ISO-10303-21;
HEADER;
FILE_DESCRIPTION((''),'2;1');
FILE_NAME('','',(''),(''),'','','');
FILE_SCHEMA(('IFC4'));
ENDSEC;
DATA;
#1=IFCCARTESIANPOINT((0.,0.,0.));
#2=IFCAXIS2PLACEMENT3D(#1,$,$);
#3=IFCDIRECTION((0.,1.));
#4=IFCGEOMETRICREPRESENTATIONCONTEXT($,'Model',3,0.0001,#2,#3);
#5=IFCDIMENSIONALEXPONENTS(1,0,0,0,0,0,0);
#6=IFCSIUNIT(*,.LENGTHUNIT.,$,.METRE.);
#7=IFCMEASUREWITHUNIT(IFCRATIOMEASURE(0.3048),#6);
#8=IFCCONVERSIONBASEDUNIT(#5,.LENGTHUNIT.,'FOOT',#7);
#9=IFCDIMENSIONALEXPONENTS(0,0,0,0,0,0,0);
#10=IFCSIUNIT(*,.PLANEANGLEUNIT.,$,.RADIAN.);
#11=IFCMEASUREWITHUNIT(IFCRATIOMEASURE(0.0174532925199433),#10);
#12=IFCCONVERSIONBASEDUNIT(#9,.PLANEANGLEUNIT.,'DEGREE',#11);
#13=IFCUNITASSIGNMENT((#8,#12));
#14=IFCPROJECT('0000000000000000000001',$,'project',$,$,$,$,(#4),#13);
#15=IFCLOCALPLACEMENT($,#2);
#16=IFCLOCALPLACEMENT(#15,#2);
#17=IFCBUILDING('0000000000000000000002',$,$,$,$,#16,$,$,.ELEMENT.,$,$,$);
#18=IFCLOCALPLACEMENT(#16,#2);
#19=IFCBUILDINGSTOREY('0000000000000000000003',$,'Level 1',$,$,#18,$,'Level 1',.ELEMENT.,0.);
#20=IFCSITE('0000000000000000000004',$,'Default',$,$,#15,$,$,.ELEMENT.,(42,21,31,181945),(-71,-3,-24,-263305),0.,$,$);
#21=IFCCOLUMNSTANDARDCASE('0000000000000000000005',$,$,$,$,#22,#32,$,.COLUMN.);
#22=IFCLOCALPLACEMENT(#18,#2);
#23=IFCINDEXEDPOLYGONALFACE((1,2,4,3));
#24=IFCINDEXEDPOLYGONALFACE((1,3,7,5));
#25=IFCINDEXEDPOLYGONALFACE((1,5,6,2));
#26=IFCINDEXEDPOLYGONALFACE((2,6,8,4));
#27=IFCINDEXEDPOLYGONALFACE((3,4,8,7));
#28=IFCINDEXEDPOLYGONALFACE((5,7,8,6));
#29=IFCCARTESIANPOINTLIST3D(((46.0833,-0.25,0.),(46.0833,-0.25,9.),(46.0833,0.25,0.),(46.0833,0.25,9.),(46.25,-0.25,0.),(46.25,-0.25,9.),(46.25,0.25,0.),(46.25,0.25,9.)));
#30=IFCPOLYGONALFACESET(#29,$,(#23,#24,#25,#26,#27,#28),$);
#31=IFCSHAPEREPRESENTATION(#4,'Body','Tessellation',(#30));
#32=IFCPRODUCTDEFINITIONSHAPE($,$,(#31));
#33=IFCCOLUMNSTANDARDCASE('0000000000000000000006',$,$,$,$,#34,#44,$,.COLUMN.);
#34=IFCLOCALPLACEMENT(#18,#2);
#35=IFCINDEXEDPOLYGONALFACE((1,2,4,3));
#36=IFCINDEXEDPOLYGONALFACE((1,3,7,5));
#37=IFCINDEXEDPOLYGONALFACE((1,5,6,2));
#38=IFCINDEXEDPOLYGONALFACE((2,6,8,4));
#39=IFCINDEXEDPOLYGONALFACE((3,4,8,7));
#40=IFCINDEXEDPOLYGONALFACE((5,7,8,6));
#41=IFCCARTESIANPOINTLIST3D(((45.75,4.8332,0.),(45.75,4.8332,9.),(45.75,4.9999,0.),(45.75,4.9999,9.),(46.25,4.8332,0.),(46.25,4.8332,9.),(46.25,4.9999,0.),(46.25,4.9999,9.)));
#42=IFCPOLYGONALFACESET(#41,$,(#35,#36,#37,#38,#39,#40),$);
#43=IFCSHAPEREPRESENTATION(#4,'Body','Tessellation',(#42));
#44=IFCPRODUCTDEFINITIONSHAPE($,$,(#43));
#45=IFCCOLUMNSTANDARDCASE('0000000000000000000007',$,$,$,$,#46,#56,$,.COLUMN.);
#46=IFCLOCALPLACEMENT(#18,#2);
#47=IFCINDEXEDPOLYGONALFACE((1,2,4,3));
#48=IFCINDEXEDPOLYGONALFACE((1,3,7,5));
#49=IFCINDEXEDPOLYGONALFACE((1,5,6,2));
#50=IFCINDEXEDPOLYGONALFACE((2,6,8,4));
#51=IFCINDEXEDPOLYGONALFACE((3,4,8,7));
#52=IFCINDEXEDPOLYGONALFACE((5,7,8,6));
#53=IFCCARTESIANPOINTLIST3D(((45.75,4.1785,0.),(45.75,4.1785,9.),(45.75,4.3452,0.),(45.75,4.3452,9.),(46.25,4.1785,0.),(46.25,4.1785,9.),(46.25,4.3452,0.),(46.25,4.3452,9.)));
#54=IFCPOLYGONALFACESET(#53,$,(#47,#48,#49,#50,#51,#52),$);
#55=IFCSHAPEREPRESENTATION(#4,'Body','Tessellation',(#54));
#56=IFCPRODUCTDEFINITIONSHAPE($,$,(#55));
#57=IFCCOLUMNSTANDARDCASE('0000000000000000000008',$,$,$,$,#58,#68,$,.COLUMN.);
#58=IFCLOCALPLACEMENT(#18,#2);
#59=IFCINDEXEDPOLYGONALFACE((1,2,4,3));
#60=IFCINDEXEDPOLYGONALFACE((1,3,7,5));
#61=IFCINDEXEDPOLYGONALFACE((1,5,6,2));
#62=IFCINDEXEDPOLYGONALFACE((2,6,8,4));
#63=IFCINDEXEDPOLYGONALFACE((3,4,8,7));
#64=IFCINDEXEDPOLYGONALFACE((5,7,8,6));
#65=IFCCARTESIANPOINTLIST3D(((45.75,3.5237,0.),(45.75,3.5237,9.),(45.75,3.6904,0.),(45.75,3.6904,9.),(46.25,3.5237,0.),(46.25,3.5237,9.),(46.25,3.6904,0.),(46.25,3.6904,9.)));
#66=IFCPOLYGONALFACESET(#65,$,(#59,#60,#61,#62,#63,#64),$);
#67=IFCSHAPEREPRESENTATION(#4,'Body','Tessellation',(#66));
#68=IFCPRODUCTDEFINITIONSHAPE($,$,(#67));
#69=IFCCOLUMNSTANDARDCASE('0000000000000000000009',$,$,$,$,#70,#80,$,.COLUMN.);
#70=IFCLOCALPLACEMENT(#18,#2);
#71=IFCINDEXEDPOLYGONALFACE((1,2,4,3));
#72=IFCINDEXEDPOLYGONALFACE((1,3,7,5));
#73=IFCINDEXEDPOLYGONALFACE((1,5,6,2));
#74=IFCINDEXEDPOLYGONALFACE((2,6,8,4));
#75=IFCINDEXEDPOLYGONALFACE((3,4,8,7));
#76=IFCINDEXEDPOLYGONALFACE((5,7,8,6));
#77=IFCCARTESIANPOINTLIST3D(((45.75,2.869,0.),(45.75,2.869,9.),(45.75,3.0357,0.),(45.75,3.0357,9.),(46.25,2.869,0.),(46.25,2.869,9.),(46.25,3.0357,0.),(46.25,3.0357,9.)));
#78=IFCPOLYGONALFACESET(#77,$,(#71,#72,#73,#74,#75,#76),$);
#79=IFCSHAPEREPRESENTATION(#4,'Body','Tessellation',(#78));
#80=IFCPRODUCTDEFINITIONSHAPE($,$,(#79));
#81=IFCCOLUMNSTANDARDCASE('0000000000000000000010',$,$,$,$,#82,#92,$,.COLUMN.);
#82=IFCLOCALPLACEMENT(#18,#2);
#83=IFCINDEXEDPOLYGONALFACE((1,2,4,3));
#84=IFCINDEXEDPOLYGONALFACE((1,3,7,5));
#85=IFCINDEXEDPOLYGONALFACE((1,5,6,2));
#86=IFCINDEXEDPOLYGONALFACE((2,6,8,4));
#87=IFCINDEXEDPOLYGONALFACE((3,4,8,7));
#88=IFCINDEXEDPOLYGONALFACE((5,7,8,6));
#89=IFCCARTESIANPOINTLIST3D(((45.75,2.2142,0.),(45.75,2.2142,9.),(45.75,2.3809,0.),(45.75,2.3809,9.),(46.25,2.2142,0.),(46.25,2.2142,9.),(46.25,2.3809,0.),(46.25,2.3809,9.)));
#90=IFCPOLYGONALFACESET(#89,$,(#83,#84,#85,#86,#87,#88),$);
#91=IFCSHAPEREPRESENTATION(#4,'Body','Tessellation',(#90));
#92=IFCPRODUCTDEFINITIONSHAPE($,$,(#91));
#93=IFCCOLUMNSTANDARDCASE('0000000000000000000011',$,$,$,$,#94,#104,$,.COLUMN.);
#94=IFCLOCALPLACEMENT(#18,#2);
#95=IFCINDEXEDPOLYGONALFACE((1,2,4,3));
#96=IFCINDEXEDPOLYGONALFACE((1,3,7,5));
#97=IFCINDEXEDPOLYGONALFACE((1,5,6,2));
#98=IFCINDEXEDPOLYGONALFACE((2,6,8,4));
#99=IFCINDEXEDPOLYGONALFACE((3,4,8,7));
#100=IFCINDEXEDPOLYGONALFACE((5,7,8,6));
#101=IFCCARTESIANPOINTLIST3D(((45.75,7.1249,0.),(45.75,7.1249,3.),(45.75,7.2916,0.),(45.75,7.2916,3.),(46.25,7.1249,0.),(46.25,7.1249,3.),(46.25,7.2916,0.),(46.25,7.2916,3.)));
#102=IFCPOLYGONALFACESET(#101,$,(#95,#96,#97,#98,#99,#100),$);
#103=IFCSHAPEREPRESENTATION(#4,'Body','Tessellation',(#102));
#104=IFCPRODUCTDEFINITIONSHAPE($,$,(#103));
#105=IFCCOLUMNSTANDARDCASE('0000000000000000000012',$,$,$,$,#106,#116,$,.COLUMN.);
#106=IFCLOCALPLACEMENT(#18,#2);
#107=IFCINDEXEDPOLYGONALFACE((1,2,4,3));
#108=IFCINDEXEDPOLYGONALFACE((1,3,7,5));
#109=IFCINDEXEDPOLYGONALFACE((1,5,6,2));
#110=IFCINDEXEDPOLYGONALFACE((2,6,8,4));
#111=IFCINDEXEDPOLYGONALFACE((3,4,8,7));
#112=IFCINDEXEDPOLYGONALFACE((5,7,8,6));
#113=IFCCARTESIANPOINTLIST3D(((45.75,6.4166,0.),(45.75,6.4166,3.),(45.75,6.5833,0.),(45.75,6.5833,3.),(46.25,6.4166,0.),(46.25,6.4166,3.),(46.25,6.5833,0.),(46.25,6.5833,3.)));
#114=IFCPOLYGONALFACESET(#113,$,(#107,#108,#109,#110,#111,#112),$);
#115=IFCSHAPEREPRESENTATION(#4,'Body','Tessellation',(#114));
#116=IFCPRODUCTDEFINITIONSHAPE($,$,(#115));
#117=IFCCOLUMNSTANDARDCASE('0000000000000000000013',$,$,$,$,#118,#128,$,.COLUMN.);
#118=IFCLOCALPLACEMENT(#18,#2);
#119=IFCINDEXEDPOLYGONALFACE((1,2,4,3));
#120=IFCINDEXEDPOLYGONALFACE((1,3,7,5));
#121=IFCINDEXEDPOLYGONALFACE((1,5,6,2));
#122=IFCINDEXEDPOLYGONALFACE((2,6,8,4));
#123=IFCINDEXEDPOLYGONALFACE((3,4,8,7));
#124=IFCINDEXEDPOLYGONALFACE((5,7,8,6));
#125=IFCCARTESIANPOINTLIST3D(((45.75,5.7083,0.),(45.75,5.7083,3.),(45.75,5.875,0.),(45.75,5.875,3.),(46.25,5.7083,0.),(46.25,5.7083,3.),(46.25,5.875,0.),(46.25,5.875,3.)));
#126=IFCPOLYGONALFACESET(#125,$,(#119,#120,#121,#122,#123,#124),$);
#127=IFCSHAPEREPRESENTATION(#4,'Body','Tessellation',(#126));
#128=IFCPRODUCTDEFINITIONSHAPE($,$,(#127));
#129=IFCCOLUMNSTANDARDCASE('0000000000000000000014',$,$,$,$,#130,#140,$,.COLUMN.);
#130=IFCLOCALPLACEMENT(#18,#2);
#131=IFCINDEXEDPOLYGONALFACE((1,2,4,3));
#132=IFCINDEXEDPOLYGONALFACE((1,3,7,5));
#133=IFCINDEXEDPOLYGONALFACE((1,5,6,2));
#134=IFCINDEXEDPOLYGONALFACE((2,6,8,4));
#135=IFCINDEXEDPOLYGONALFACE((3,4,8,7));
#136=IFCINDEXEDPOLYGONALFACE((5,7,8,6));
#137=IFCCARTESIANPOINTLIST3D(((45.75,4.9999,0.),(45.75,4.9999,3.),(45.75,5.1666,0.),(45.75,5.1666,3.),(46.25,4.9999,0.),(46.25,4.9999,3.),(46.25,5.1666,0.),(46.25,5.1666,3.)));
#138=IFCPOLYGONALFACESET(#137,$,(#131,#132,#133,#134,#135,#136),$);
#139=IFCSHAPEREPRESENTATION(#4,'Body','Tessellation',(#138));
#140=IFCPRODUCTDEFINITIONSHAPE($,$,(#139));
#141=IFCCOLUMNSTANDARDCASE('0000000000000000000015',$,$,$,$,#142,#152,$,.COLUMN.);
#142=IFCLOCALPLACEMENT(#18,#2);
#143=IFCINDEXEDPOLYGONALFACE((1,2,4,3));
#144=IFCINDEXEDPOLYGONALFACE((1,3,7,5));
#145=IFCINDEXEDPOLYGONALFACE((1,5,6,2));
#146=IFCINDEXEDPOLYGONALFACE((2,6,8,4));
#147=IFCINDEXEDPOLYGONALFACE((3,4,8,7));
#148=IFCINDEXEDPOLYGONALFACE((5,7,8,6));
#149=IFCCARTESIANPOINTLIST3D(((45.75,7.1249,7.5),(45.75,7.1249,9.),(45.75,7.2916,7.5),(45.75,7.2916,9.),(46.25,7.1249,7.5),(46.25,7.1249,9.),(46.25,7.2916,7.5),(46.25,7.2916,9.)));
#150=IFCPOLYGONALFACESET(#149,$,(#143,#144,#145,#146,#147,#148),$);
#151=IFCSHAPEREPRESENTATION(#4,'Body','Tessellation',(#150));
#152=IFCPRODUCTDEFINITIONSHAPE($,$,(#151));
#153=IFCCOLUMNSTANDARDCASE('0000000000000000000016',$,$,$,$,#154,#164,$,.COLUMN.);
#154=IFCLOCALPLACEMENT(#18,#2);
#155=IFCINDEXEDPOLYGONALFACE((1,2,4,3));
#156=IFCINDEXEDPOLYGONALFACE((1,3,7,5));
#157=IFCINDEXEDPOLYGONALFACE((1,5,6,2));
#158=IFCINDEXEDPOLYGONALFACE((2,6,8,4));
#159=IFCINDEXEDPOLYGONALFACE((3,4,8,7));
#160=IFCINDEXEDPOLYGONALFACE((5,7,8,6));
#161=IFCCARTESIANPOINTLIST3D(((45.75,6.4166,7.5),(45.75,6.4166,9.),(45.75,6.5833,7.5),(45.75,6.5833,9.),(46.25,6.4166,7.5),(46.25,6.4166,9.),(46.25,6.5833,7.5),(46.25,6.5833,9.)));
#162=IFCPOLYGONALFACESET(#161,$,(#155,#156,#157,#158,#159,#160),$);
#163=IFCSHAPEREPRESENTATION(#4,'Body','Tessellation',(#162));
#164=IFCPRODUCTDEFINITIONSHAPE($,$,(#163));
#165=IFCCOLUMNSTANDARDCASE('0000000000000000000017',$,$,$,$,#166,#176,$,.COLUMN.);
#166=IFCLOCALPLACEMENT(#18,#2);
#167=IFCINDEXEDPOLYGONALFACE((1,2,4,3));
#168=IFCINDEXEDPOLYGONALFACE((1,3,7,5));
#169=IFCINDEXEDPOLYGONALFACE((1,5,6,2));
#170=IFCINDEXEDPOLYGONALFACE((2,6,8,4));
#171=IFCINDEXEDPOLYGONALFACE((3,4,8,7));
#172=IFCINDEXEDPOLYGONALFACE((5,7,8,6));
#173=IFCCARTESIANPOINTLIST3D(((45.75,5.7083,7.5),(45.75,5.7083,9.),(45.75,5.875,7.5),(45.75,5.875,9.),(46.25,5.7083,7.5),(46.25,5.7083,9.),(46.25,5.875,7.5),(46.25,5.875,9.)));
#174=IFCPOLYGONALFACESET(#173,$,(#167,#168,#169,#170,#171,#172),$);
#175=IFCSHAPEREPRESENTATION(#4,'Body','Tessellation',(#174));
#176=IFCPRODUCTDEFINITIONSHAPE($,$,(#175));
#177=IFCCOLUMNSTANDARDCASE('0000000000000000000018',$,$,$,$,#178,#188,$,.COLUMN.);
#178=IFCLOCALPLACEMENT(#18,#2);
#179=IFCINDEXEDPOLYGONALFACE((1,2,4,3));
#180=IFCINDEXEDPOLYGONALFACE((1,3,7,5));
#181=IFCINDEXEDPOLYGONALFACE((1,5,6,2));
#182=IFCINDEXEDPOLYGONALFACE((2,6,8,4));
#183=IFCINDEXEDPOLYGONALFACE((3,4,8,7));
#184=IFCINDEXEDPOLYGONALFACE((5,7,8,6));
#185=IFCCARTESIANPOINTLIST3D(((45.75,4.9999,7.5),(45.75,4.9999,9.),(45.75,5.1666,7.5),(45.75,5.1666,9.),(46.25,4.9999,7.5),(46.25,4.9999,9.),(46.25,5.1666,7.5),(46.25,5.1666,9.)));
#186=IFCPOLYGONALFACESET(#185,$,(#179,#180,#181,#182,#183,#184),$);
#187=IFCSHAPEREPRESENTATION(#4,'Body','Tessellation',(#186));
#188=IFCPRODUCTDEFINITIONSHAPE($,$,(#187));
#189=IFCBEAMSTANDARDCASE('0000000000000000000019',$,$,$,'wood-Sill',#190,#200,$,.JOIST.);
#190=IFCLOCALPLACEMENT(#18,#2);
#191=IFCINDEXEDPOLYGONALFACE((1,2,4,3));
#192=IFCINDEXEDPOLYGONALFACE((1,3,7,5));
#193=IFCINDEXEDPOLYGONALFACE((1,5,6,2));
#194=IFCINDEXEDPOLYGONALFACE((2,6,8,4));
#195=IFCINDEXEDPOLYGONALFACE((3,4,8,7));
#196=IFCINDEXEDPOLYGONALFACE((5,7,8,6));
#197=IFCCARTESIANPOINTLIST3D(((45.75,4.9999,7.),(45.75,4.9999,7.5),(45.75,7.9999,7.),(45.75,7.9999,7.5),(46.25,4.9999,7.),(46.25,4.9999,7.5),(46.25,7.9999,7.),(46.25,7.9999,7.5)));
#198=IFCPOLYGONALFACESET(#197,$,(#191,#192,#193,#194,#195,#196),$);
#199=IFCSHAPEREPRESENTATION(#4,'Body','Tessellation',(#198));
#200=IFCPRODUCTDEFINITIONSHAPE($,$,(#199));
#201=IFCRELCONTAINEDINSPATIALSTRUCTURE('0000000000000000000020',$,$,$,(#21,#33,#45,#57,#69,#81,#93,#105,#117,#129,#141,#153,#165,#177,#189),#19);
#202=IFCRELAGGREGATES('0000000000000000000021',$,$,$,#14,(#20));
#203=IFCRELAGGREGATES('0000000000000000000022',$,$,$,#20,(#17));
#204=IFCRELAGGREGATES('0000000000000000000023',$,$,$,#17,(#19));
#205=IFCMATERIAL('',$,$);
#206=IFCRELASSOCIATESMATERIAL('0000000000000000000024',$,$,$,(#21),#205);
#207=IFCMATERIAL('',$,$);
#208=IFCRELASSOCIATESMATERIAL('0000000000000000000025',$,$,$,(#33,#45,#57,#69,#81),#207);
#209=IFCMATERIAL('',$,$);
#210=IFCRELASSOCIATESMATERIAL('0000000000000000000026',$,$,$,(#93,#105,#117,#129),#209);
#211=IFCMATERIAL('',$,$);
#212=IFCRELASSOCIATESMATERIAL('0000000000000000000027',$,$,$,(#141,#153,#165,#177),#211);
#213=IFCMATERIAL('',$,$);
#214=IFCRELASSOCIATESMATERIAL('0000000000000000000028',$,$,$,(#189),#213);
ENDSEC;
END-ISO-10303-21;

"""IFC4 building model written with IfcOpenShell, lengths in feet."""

from ifc_helpers import new_model, entity, si_unit, converted_unit, direction, frame, origin, place, context, project, spatial, rectangle, extrude, material, element, save


model = new_model("IFC4")

# Units and contexts
model_context = context("Model", 3, precision=0.0001, world=origin(), true_north=direction((0.0, 1.0)))
ifc_project = project(units=[converted_unit("LENGTHUNIT", "FOOT", entity("IfcRatioMeasure", 0.3048), si_unit("LENGTHUNIT", "METRE"), dimensions=[1, 0, 0, 0, 0, 0, 0]), converted_unit("PLANEANGLEUNIT", "DEGREE", entity("IfcRatioMeasure", 0.0174532925199433), si_unit("PLANEANGLEUNIT", "RADIAN"), dimensions=[0, 0, 0, 0, 0, 0, 0])], contexts=[model_context])

# Site, building, storey
site_placement = place(None, origin())
site = spatial("IfcSite", under=ifc_project, at=site_placement, Name="Default", CompositionType="ELEMENT", RefLatitude=(42, 21, 31, 181945), RefLongitude=(-71, -3, -24, -263305), RefElevation=0.0)
building_placement = place(site_placement, origin())
building = spatial("IfcBuilding", under=site, at=building_placement, CompositionType="ELEMENT")
storey_placement = place(building_placement, origin())
storey = spatial("IfcBuildingStorey", under=building, at=storey_placement, Name="Level 1", LongName="Level 1", CompositionType="ELEMENT", Elevation=0.0)

# Columns
ifc_material_1 = material(Name="")
placement_1 = place(storey_placement, frame((46.25, 0.0, 0.0), z_axis=(0.0, 0.0, 1.0), x_axis=(-1.0, 0.0, 0.0)))
column_placement = place(placement_1, frame((0.0833, 0.0, 0.0), z_axis=(0.0, 0.0, 1.0), x_axis=(1.0, 0.0, 0.0)))
element("IfcColumnStandardCase", 1, at=column_placement, inside=storey, material=ifc_material_1, PredefinedType="COLUMN", context=model_context, shape_type="SweptSolid", body=[
    extrude(rectangle(XDim=0.1667, YDim=0.5), origin(), (0.0, 0.0, 1.0), 9.0),
])
ifc_material_2 = material(Name="")
placement_2 = place(storey_placement, frame((46.0, 46.25, 0.0), z_axis=(0.0, 0.0, 1.0), x_axis=(0.0, -1.0, 0.0)))
for number, where, z_axis, x_axis in (
    (2, (41.3335, 0.0, 0.0), (0.0, 0.0, 1.0), (1.0, 0.0, 0.0)),
    (3, (41.9882, 0.0, 0.0), (0.0, 0.0, 1.0), (1.0, 0.0, 0.0)),
    (4, (42.643, 0.0, 0.0), (0.0, 0.0, 1.0), (1.0, 0.0, 0.0)),
    (5, (43.2977, 0.0, 0.0), (0.0, 0.0, 1.0), (1.0, 0.0, 0.0)),
    (6, (43.9525, 0.0, 0.0), (0.0, 0.0, 1.0), (1.0, 0.0, 0.0)),
):
    element("IfcColumnStandardCase", number, at=place(placement_2, frame(where, z_axis=z_axis, x_axis=x_axis)), inside=storey, material=ifc_material_2, PredefinedType="COLUMN", context=model_context, shape_type="SweptSolid", body=[
        extrude(rectangle(XDim=0.1667, YDim=0.5), origin(), (0.0, 0.0, 1.0), 9.0),
    ])
ifc_material_3 = material(Name="")
for number, where, z_axis, x_axis in (
    (7, (39.0418, 0.0, 0.0), (0.0, 0.0, 1.0), (1.0, 0.0, 0.0)),
    (8, (39.7501, 0.0, 0.0), (0.0, 0.0, 1.0), (1.0, 0.0, 0.0)),
    (9, (40.4584, 0.0, 0.0), (0.0, 0.0, 1.0), (1.0, 0.0, 0.0)),
    (10, (41.1668, 0.0, 0.0), (0.0, 0.0, 1.0), (1.0, 0.0, 0.0)),
):
    element("IfcColumnStandardCase", number, at=place(placement_2, frame(where, z_axis=z_axis, x_axis=x_axis)), inside=storey, material=ifc_material_3, PredefinedType="COLUMN", context=model_context, shape_type="SweptSolid", body=[
        extrude(rectangle(XDim=0.1667, YDim=0.5), origin(), (0.0, 0.0, 1.0), 3.0),
    ])
ifc_material_4 = material(Name="")
for number, where, z_axis, x_axis in (
    (11, (39.0418, 0.0, 7.5), (0.0, 0.0, 1.0), (1.0, 0.0, 0.0)),
    (12, (39.7501, 0.0, 7.5), (0.0, 0.0, 1.0), (1.0, 0.0, 0.0)),
    (13, (40.4584, 0.0, 7.5), (0.0, 0.0, 1.0), (1.0, 0.0, 0.0)),
    (14, (41.1668, 0.0, 7.5), (0.0, 0.0, 1.0), (1.0, 0.0, 0.0)),
):
    element("IfcColumnStandardCase", number, at=place(placement_2, frame(where, z_axis=z_axis, x_axis=x_axis)), inside=storey, material=ifc_material_4, PredefinedType="COLUMN", context=model_context, shape_type="SweptSolid", body=[
        extrude(rectangle(XDim=0.1667, YDim=0.5), origin(), (0.0, 0.0, 1.0), 1.5),
    ])

# Beam
ifc_material_5 = material(Name="")
for number, where, z_axis, x_axis in (
    (15, (39.7501, 0.0, 7.0), (0.0, 0.0, 1.0), (-1.0, 0.0, 0.0)),
):
    element("IfcBeamStandardCase", number, at=place(placement_2, frame(where, z_axis=z_axis, x_axis=x_axis)), inside=storey, material=ifc_material_5, ObjectType="wood-Sill", PredefinedType="JOIST", context=model_context, shape_type="SweptSolid", body=[
        extrude(rectangle(XDim=3.0, YDim=0.5), origin(), (0.0, 0.0, 1.0), 0.5),
    ])

save(model, "model.ifc")
